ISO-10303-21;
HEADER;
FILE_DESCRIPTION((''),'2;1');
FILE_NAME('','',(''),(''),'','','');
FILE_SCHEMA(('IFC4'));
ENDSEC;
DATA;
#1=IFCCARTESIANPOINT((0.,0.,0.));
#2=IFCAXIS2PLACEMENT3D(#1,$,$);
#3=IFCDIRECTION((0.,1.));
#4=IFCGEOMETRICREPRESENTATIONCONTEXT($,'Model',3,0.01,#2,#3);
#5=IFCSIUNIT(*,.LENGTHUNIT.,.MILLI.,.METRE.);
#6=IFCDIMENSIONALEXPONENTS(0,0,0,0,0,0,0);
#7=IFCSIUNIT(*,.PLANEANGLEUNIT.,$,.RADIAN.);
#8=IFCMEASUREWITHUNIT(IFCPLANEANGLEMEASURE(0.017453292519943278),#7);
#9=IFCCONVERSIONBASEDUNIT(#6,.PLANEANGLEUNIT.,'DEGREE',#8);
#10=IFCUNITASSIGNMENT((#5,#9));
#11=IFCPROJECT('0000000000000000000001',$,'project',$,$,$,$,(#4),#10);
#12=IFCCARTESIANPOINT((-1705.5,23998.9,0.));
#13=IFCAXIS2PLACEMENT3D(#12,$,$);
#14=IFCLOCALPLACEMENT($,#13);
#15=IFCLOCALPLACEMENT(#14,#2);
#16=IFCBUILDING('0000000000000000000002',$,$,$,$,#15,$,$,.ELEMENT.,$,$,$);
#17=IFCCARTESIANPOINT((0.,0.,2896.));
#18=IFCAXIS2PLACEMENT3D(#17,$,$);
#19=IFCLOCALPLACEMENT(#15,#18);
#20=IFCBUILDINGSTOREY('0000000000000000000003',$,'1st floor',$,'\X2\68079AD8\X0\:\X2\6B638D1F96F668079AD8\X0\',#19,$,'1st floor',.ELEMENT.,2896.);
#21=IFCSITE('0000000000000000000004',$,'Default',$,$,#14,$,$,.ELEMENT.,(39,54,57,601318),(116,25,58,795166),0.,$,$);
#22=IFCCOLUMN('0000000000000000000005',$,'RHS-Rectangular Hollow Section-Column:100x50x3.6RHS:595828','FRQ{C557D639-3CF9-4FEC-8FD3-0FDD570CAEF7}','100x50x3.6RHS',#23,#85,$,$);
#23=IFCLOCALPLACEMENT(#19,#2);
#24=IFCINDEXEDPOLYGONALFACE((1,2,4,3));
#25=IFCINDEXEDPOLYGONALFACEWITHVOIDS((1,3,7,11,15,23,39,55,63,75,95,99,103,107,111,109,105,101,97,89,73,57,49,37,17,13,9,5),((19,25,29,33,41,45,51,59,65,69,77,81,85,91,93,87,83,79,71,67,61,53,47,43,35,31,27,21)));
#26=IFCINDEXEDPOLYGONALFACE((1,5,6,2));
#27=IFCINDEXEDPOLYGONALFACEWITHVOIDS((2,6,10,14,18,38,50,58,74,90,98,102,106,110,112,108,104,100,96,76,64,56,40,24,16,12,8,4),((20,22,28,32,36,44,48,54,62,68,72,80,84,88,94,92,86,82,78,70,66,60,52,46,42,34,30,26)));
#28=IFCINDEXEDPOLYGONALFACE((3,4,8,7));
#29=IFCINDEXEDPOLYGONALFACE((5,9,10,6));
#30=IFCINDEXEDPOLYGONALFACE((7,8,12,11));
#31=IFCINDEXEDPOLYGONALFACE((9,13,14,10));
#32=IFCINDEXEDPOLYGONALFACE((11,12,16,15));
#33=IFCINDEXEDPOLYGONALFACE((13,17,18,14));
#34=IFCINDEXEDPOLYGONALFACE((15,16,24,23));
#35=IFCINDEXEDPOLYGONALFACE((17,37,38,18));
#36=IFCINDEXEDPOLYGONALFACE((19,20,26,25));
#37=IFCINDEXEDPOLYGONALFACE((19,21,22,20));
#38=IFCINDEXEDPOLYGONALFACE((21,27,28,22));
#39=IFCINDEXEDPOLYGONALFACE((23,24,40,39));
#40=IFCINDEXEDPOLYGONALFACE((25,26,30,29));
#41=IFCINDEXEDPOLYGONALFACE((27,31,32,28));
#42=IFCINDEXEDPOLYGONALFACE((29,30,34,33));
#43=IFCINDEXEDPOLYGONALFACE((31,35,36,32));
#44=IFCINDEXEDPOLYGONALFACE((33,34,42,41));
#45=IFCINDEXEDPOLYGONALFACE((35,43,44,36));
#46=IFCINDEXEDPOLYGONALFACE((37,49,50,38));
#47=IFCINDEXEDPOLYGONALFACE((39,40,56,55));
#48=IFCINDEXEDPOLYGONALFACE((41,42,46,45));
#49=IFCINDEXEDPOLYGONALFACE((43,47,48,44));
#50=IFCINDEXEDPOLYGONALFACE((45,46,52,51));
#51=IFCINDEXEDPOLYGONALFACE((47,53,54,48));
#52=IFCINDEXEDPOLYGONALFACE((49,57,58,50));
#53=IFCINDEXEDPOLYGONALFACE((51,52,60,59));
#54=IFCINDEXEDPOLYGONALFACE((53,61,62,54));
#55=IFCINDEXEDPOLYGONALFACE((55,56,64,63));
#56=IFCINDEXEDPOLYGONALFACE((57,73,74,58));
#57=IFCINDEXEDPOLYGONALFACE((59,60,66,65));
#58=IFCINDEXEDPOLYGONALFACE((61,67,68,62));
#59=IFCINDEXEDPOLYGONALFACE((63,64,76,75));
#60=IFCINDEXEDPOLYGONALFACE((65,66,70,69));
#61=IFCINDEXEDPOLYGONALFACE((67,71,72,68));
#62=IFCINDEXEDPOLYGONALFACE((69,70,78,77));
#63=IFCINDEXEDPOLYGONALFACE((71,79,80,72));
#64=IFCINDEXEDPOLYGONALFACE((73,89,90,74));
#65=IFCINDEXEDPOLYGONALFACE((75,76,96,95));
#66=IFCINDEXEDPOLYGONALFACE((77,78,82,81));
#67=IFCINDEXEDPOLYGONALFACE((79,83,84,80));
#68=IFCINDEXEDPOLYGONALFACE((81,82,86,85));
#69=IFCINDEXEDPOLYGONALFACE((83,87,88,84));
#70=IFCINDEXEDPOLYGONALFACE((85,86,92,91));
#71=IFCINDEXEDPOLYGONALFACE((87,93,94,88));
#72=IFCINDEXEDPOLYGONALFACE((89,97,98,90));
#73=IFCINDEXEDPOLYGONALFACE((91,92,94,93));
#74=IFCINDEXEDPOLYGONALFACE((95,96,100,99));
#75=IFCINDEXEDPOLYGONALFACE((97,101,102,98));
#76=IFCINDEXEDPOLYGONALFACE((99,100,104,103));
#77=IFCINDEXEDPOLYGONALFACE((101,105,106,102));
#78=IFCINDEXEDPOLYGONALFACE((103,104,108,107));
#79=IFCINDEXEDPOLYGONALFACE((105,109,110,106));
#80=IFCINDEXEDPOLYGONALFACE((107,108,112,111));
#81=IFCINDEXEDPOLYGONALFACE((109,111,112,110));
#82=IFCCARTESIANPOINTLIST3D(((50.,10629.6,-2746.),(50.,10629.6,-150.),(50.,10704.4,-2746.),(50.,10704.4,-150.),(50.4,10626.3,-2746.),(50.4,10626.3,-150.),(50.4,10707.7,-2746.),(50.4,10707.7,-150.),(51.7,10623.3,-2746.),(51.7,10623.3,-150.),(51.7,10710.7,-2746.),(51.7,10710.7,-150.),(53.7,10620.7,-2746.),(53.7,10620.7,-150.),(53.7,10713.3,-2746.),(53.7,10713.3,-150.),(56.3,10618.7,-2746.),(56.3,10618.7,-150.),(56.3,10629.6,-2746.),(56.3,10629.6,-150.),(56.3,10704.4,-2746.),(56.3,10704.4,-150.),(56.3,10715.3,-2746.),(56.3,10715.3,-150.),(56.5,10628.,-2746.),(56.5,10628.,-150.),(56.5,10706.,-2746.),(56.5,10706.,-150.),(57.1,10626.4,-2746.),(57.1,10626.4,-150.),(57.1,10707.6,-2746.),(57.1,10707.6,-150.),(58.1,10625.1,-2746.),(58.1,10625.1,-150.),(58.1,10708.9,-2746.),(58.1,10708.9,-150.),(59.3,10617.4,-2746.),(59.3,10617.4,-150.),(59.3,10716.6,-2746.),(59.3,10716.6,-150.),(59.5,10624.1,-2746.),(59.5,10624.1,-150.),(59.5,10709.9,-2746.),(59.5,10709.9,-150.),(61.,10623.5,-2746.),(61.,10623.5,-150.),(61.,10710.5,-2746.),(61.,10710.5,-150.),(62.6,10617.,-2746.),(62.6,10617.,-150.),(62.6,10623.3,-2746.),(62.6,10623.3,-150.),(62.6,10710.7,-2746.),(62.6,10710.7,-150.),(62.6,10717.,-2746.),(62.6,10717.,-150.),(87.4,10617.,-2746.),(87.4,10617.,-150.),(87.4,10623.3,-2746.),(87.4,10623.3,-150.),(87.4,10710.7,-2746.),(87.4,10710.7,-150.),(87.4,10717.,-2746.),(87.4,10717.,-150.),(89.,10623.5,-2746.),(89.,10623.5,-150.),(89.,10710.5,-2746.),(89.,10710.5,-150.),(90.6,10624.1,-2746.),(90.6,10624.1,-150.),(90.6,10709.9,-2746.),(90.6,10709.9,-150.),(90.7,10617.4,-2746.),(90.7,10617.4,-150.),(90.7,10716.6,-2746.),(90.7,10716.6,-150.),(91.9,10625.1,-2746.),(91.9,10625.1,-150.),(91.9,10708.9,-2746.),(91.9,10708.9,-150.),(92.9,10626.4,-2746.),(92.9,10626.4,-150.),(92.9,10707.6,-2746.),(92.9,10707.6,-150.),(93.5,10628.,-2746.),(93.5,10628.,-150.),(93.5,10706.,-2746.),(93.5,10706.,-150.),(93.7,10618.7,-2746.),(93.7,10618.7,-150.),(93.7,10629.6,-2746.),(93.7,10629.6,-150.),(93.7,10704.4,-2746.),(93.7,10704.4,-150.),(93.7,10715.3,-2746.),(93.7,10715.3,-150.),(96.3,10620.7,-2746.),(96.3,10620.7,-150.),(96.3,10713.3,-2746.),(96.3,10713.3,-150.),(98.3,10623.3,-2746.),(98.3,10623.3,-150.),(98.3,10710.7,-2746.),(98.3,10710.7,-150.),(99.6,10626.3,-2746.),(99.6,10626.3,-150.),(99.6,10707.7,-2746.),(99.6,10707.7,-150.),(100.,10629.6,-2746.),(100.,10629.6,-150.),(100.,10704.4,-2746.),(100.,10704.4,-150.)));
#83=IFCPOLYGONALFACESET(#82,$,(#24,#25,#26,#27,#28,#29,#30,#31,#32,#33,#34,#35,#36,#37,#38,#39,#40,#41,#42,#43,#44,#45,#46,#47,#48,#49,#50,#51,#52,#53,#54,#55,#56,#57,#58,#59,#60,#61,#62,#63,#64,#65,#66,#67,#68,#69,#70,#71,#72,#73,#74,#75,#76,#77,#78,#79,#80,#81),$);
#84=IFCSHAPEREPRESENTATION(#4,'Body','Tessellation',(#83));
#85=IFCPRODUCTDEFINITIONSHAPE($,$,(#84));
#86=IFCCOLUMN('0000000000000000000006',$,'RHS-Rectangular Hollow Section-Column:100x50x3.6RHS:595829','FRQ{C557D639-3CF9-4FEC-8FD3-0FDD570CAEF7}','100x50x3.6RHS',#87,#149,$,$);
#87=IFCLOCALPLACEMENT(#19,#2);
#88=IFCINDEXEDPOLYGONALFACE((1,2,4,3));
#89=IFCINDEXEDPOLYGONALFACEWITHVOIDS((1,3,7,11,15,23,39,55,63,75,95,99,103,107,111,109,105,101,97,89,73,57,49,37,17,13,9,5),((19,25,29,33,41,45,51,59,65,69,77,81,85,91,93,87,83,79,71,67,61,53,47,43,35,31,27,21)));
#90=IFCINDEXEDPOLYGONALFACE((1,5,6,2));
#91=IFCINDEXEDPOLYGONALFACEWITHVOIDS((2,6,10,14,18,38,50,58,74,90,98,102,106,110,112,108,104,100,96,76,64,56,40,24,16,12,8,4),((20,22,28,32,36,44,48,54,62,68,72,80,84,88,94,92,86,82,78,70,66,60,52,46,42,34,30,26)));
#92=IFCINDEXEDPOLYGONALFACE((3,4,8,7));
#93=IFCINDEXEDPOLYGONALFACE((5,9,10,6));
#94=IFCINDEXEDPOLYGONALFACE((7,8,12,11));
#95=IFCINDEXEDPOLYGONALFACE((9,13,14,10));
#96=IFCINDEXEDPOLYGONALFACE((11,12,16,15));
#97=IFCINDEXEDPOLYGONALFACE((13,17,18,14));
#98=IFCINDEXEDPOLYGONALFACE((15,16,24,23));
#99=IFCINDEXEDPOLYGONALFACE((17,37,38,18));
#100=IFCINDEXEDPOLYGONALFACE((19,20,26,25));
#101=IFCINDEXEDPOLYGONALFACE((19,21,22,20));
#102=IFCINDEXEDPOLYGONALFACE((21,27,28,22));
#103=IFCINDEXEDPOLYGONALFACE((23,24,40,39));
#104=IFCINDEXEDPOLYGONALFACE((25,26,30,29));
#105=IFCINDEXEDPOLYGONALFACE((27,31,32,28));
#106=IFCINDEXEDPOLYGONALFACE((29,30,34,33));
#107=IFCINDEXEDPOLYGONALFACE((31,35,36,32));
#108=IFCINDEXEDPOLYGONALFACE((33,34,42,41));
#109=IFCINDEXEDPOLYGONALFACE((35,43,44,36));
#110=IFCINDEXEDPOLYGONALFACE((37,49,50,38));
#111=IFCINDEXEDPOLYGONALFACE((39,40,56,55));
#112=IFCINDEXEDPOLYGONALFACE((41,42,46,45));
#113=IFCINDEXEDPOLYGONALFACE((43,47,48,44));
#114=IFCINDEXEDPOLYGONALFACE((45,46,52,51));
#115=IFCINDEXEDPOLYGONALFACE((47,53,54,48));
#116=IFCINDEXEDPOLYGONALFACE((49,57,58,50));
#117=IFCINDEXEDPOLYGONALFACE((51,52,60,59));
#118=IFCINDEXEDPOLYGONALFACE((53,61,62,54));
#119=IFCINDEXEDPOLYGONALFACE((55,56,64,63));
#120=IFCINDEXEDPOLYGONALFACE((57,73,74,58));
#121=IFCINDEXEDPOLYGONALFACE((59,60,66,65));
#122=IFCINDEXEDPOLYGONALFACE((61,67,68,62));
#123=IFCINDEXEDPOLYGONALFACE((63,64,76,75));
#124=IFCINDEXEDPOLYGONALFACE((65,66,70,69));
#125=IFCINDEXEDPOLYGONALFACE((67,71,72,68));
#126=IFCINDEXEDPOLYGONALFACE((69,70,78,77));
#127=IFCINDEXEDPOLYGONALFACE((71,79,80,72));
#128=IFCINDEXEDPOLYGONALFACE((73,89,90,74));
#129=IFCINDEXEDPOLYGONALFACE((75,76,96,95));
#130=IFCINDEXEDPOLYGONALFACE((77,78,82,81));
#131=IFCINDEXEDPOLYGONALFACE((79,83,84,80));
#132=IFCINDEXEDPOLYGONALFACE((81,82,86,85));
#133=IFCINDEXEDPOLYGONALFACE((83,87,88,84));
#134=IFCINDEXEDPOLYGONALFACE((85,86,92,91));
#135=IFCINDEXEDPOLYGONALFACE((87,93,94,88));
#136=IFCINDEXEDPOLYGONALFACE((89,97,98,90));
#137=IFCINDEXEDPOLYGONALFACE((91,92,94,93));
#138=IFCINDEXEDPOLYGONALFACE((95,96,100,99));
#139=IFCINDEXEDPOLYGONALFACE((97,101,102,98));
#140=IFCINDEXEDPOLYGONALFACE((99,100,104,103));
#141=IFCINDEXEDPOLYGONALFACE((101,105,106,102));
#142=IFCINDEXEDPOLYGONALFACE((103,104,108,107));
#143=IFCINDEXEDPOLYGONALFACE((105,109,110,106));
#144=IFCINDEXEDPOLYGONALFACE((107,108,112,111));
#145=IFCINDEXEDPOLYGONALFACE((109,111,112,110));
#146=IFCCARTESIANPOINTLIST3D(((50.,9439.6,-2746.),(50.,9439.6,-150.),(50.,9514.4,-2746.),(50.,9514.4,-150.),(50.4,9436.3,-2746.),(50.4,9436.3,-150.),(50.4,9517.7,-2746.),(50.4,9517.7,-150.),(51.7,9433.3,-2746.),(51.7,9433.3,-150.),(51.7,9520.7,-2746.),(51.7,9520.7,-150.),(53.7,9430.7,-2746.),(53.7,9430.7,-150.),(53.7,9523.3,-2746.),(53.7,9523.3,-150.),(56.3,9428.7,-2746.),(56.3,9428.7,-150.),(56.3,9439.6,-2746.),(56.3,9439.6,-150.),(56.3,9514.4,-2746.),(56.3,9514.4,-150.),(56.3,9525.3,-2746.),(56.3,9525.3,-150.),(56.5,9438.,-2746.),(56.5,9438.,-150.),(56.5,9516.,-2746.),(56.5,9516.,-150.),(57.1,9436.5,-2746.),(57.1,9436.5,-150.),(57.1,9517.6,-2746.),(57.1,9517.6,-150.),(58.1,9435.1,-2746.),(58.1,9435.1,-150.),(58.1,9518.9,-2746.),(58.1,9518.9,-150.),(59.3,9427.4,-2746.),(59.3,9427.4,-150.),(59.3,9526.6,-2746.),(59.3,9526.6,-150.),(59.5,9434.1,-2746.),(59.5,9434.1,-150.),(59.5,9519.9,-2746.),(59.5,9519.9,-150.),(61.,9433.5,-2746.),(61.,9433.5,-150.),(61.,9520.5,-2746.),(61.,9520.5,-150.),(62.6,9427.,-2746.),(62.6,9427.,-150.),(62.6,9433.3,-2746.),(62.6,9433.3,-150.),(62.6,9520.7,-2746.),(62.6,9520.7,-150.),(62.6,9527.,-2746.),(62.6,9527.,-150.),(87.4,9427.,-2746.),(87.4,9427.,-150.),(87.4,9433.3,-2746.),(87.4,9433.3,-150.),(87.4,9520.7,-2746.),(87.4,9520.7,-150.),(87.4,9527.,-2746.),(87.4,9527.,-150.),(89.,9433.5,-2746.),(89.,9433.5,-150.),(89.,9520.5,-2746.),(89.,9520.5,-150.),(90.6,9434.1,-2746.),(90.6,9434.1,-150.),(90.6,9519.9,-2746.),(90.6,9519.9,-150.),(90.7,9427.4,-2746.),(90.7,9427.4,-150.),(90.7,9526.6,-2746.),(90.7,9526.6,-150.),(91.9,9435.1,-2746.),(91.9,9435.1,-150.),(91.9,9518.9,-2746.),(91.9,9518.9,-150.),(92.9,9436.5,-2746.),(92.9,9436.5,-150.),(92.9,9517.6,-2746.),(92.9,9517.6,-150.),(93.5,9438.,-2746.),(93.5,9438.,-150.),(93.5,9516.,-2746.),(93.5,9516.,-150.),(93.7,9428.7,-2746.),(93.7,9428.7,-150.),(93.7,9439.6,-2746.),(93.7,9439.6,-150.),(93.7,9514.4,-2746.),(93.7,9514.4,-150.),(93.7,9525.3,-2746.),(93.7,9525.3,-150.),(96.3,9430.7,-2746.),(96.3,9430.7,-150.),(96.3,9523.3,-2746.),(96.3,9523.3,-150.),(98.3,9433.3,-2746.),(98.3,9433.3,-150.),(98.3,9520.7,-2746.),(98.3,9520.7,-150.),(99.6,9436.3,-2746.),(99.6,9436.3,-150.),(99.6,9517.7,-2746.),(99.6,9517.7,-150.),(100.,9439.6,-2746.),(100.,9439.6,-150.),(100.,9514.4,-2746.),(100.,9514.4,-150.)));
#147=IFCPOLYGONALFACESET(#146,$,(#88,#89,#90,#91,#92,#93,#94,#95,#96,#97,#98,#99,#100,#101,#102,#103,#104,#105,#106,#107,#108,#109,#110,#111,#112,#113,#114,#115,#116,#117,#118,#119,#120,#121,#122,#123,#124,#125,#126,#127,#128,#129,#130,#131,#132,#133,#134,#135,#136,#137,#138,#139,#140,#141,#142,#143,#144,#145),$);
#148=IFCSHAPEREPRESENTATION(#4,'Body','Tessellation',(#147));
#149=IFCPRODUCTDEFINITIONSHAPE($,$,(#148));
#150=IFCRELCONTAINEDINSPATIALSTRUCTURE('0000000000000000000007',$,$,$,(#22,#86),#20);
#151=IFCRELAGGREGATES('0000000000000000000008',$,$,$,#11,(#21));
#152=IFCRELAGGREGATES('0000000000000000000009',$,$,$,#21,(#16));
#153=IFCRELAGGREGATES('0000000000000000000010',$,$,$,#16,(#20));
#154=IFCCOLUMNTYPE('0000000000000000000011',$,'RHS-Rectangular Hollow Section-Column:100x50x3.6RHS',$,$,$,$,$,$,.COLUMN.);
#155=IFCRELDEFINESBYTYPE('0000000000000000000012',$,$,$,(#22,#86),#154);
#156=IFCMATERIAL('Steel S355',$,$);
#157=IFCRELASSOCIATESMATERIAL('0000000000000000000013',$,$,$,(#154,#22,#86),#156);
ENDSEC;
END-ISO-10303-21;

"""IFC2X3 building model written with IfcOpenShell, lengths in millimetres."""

from ifc_helpers import new_model, entity, si_unit, converted_unit, direction, frame, origin, origin_2d, place, context, project, spatial, hollow_rectangle, extrude, clip, halfspace, material, type_object, element, save


model = new_model("IFC2X3")

# Units and contexts
model_context = context("Model", 3, precision=0.01, world=origin(), true_north=direction((0.0, 1.0)))
ifc_project = project(units=[si_unit("LENGTHUNIT", "METRE", prefix="MILLI"), converted_unit("PLANEANGLEUNIT", "DEGREE", entity("IfcPlaneAngleMeasure", 0.017453292519943278), si_unit("PLANEANGLEUNIT", "RADIAN"), dimensions=[0, 0, 0, 0, 0, 0, 0])], contexts=[model_context])

# Site, building, storey
site_placement = place(None, frame((-1705.5, 23998.9, 0.0)))
site = spatial("IfcSite", under=ifc_project, at=site_placement, Name="Default", CompositionType="ELEMENT", RefLatitude=(39, 54, 57, 601318), RefLongitude=(116, 25, 58, 795166), RefElevation=0.0)
building_placement = place(site_placement, origin())
building = spatial("IfcBuilding", under=site, at=building_placement, CompositionType="ELEMENT")
storey_placement = place(building_placement, frame((0.0, 0.0, 2896.0)))
storey = spatial("IfcBuildingStorey", under=building, at=storey_placement, Name="1st floor", ObjectType="标高:正负零标高", LongName="1st floor", CompositionType="ELEMENT", Elevation=2896.0)

# Columns
ifc_material_1 = material(Name="Steel S355")
column_type = type_object("IfcColumnType", Name="RHS-Rectangular Hollow Section-Column:100x50x3.6RHS", PredefinedType="COLUMN", material=ifc_material_1)
column_1_placement = place(storey_placement, frame((75.0, 10667.0, -150.0), z_axis=(0.0, 0.0, 1.0), x_axis=(-1.0, 0.0, 0.0)))
element("IfcColumn", 1, at=column_1_placement, inside=storey, type_object=column_type, material=ifc_material_1, Name="RHS-Rectangular Hollow Section-Column:100x50x3.6RHS:595828", Description="FRQ{C557D639-3CF9-4FEC-8FD3-0FDD570CAEF7}", ObjectType="100x50x3.6RHS", context=model_context, shape_type="Clipping", body=[
    clip(extrude(hollow_rectangle(XDim=50.0, YDim=100.0, WallThickness=6.3, InnerFilletRadius=6.3, OuterFilletRadius=12.6, at=origin_2d()), origin(), (0.0, 0.0, -1.0), 2651.9), halfspace(frame((75.0, 10667.0, -2596.0), z_axis=(0.0, 0.0, 1.0), x_axis=(-1.0, 0.0, 0.0)), True)),
])
column_2_placement = place(storey_placement, frame((75.0, 9477.0, -150.0), z_axis=(0.0, 0.0, 1.0), x_axis=(-1.0, 0.0, 0.0)))
element("IfcColumn", 2, at=column_2_placement, inside=storey, type_object=column_type, material=ifc_material_1, Name="RHS-Rectangular Hollow Section-Column:100x50x3.6RHS:595829", Description="FRQ{C557D639-3CF9-4FEC-8FD3-0FDD570CAEF7}", ObjectType="100x50x3.6RHS", context=model_context, shape_type="Clipping", body=[
    clip(extrude(hollow_rectangle(XDim=50.0, YDim=100.0, WallThickness=6.3, InnerFilletRadius=6.3, OuterFilletRadius=12.6, at=origin_2d()), origin(), (0.0, 0.0, -1.0), 2651.9), halfspace(frame((75.0, 9477.0, -2596.0), z_axis=(0.0, 0.0, 1.0), x_axis=(-1.0, 0.0, 0.0)), True)),
])

save(model, "model.ifc")
